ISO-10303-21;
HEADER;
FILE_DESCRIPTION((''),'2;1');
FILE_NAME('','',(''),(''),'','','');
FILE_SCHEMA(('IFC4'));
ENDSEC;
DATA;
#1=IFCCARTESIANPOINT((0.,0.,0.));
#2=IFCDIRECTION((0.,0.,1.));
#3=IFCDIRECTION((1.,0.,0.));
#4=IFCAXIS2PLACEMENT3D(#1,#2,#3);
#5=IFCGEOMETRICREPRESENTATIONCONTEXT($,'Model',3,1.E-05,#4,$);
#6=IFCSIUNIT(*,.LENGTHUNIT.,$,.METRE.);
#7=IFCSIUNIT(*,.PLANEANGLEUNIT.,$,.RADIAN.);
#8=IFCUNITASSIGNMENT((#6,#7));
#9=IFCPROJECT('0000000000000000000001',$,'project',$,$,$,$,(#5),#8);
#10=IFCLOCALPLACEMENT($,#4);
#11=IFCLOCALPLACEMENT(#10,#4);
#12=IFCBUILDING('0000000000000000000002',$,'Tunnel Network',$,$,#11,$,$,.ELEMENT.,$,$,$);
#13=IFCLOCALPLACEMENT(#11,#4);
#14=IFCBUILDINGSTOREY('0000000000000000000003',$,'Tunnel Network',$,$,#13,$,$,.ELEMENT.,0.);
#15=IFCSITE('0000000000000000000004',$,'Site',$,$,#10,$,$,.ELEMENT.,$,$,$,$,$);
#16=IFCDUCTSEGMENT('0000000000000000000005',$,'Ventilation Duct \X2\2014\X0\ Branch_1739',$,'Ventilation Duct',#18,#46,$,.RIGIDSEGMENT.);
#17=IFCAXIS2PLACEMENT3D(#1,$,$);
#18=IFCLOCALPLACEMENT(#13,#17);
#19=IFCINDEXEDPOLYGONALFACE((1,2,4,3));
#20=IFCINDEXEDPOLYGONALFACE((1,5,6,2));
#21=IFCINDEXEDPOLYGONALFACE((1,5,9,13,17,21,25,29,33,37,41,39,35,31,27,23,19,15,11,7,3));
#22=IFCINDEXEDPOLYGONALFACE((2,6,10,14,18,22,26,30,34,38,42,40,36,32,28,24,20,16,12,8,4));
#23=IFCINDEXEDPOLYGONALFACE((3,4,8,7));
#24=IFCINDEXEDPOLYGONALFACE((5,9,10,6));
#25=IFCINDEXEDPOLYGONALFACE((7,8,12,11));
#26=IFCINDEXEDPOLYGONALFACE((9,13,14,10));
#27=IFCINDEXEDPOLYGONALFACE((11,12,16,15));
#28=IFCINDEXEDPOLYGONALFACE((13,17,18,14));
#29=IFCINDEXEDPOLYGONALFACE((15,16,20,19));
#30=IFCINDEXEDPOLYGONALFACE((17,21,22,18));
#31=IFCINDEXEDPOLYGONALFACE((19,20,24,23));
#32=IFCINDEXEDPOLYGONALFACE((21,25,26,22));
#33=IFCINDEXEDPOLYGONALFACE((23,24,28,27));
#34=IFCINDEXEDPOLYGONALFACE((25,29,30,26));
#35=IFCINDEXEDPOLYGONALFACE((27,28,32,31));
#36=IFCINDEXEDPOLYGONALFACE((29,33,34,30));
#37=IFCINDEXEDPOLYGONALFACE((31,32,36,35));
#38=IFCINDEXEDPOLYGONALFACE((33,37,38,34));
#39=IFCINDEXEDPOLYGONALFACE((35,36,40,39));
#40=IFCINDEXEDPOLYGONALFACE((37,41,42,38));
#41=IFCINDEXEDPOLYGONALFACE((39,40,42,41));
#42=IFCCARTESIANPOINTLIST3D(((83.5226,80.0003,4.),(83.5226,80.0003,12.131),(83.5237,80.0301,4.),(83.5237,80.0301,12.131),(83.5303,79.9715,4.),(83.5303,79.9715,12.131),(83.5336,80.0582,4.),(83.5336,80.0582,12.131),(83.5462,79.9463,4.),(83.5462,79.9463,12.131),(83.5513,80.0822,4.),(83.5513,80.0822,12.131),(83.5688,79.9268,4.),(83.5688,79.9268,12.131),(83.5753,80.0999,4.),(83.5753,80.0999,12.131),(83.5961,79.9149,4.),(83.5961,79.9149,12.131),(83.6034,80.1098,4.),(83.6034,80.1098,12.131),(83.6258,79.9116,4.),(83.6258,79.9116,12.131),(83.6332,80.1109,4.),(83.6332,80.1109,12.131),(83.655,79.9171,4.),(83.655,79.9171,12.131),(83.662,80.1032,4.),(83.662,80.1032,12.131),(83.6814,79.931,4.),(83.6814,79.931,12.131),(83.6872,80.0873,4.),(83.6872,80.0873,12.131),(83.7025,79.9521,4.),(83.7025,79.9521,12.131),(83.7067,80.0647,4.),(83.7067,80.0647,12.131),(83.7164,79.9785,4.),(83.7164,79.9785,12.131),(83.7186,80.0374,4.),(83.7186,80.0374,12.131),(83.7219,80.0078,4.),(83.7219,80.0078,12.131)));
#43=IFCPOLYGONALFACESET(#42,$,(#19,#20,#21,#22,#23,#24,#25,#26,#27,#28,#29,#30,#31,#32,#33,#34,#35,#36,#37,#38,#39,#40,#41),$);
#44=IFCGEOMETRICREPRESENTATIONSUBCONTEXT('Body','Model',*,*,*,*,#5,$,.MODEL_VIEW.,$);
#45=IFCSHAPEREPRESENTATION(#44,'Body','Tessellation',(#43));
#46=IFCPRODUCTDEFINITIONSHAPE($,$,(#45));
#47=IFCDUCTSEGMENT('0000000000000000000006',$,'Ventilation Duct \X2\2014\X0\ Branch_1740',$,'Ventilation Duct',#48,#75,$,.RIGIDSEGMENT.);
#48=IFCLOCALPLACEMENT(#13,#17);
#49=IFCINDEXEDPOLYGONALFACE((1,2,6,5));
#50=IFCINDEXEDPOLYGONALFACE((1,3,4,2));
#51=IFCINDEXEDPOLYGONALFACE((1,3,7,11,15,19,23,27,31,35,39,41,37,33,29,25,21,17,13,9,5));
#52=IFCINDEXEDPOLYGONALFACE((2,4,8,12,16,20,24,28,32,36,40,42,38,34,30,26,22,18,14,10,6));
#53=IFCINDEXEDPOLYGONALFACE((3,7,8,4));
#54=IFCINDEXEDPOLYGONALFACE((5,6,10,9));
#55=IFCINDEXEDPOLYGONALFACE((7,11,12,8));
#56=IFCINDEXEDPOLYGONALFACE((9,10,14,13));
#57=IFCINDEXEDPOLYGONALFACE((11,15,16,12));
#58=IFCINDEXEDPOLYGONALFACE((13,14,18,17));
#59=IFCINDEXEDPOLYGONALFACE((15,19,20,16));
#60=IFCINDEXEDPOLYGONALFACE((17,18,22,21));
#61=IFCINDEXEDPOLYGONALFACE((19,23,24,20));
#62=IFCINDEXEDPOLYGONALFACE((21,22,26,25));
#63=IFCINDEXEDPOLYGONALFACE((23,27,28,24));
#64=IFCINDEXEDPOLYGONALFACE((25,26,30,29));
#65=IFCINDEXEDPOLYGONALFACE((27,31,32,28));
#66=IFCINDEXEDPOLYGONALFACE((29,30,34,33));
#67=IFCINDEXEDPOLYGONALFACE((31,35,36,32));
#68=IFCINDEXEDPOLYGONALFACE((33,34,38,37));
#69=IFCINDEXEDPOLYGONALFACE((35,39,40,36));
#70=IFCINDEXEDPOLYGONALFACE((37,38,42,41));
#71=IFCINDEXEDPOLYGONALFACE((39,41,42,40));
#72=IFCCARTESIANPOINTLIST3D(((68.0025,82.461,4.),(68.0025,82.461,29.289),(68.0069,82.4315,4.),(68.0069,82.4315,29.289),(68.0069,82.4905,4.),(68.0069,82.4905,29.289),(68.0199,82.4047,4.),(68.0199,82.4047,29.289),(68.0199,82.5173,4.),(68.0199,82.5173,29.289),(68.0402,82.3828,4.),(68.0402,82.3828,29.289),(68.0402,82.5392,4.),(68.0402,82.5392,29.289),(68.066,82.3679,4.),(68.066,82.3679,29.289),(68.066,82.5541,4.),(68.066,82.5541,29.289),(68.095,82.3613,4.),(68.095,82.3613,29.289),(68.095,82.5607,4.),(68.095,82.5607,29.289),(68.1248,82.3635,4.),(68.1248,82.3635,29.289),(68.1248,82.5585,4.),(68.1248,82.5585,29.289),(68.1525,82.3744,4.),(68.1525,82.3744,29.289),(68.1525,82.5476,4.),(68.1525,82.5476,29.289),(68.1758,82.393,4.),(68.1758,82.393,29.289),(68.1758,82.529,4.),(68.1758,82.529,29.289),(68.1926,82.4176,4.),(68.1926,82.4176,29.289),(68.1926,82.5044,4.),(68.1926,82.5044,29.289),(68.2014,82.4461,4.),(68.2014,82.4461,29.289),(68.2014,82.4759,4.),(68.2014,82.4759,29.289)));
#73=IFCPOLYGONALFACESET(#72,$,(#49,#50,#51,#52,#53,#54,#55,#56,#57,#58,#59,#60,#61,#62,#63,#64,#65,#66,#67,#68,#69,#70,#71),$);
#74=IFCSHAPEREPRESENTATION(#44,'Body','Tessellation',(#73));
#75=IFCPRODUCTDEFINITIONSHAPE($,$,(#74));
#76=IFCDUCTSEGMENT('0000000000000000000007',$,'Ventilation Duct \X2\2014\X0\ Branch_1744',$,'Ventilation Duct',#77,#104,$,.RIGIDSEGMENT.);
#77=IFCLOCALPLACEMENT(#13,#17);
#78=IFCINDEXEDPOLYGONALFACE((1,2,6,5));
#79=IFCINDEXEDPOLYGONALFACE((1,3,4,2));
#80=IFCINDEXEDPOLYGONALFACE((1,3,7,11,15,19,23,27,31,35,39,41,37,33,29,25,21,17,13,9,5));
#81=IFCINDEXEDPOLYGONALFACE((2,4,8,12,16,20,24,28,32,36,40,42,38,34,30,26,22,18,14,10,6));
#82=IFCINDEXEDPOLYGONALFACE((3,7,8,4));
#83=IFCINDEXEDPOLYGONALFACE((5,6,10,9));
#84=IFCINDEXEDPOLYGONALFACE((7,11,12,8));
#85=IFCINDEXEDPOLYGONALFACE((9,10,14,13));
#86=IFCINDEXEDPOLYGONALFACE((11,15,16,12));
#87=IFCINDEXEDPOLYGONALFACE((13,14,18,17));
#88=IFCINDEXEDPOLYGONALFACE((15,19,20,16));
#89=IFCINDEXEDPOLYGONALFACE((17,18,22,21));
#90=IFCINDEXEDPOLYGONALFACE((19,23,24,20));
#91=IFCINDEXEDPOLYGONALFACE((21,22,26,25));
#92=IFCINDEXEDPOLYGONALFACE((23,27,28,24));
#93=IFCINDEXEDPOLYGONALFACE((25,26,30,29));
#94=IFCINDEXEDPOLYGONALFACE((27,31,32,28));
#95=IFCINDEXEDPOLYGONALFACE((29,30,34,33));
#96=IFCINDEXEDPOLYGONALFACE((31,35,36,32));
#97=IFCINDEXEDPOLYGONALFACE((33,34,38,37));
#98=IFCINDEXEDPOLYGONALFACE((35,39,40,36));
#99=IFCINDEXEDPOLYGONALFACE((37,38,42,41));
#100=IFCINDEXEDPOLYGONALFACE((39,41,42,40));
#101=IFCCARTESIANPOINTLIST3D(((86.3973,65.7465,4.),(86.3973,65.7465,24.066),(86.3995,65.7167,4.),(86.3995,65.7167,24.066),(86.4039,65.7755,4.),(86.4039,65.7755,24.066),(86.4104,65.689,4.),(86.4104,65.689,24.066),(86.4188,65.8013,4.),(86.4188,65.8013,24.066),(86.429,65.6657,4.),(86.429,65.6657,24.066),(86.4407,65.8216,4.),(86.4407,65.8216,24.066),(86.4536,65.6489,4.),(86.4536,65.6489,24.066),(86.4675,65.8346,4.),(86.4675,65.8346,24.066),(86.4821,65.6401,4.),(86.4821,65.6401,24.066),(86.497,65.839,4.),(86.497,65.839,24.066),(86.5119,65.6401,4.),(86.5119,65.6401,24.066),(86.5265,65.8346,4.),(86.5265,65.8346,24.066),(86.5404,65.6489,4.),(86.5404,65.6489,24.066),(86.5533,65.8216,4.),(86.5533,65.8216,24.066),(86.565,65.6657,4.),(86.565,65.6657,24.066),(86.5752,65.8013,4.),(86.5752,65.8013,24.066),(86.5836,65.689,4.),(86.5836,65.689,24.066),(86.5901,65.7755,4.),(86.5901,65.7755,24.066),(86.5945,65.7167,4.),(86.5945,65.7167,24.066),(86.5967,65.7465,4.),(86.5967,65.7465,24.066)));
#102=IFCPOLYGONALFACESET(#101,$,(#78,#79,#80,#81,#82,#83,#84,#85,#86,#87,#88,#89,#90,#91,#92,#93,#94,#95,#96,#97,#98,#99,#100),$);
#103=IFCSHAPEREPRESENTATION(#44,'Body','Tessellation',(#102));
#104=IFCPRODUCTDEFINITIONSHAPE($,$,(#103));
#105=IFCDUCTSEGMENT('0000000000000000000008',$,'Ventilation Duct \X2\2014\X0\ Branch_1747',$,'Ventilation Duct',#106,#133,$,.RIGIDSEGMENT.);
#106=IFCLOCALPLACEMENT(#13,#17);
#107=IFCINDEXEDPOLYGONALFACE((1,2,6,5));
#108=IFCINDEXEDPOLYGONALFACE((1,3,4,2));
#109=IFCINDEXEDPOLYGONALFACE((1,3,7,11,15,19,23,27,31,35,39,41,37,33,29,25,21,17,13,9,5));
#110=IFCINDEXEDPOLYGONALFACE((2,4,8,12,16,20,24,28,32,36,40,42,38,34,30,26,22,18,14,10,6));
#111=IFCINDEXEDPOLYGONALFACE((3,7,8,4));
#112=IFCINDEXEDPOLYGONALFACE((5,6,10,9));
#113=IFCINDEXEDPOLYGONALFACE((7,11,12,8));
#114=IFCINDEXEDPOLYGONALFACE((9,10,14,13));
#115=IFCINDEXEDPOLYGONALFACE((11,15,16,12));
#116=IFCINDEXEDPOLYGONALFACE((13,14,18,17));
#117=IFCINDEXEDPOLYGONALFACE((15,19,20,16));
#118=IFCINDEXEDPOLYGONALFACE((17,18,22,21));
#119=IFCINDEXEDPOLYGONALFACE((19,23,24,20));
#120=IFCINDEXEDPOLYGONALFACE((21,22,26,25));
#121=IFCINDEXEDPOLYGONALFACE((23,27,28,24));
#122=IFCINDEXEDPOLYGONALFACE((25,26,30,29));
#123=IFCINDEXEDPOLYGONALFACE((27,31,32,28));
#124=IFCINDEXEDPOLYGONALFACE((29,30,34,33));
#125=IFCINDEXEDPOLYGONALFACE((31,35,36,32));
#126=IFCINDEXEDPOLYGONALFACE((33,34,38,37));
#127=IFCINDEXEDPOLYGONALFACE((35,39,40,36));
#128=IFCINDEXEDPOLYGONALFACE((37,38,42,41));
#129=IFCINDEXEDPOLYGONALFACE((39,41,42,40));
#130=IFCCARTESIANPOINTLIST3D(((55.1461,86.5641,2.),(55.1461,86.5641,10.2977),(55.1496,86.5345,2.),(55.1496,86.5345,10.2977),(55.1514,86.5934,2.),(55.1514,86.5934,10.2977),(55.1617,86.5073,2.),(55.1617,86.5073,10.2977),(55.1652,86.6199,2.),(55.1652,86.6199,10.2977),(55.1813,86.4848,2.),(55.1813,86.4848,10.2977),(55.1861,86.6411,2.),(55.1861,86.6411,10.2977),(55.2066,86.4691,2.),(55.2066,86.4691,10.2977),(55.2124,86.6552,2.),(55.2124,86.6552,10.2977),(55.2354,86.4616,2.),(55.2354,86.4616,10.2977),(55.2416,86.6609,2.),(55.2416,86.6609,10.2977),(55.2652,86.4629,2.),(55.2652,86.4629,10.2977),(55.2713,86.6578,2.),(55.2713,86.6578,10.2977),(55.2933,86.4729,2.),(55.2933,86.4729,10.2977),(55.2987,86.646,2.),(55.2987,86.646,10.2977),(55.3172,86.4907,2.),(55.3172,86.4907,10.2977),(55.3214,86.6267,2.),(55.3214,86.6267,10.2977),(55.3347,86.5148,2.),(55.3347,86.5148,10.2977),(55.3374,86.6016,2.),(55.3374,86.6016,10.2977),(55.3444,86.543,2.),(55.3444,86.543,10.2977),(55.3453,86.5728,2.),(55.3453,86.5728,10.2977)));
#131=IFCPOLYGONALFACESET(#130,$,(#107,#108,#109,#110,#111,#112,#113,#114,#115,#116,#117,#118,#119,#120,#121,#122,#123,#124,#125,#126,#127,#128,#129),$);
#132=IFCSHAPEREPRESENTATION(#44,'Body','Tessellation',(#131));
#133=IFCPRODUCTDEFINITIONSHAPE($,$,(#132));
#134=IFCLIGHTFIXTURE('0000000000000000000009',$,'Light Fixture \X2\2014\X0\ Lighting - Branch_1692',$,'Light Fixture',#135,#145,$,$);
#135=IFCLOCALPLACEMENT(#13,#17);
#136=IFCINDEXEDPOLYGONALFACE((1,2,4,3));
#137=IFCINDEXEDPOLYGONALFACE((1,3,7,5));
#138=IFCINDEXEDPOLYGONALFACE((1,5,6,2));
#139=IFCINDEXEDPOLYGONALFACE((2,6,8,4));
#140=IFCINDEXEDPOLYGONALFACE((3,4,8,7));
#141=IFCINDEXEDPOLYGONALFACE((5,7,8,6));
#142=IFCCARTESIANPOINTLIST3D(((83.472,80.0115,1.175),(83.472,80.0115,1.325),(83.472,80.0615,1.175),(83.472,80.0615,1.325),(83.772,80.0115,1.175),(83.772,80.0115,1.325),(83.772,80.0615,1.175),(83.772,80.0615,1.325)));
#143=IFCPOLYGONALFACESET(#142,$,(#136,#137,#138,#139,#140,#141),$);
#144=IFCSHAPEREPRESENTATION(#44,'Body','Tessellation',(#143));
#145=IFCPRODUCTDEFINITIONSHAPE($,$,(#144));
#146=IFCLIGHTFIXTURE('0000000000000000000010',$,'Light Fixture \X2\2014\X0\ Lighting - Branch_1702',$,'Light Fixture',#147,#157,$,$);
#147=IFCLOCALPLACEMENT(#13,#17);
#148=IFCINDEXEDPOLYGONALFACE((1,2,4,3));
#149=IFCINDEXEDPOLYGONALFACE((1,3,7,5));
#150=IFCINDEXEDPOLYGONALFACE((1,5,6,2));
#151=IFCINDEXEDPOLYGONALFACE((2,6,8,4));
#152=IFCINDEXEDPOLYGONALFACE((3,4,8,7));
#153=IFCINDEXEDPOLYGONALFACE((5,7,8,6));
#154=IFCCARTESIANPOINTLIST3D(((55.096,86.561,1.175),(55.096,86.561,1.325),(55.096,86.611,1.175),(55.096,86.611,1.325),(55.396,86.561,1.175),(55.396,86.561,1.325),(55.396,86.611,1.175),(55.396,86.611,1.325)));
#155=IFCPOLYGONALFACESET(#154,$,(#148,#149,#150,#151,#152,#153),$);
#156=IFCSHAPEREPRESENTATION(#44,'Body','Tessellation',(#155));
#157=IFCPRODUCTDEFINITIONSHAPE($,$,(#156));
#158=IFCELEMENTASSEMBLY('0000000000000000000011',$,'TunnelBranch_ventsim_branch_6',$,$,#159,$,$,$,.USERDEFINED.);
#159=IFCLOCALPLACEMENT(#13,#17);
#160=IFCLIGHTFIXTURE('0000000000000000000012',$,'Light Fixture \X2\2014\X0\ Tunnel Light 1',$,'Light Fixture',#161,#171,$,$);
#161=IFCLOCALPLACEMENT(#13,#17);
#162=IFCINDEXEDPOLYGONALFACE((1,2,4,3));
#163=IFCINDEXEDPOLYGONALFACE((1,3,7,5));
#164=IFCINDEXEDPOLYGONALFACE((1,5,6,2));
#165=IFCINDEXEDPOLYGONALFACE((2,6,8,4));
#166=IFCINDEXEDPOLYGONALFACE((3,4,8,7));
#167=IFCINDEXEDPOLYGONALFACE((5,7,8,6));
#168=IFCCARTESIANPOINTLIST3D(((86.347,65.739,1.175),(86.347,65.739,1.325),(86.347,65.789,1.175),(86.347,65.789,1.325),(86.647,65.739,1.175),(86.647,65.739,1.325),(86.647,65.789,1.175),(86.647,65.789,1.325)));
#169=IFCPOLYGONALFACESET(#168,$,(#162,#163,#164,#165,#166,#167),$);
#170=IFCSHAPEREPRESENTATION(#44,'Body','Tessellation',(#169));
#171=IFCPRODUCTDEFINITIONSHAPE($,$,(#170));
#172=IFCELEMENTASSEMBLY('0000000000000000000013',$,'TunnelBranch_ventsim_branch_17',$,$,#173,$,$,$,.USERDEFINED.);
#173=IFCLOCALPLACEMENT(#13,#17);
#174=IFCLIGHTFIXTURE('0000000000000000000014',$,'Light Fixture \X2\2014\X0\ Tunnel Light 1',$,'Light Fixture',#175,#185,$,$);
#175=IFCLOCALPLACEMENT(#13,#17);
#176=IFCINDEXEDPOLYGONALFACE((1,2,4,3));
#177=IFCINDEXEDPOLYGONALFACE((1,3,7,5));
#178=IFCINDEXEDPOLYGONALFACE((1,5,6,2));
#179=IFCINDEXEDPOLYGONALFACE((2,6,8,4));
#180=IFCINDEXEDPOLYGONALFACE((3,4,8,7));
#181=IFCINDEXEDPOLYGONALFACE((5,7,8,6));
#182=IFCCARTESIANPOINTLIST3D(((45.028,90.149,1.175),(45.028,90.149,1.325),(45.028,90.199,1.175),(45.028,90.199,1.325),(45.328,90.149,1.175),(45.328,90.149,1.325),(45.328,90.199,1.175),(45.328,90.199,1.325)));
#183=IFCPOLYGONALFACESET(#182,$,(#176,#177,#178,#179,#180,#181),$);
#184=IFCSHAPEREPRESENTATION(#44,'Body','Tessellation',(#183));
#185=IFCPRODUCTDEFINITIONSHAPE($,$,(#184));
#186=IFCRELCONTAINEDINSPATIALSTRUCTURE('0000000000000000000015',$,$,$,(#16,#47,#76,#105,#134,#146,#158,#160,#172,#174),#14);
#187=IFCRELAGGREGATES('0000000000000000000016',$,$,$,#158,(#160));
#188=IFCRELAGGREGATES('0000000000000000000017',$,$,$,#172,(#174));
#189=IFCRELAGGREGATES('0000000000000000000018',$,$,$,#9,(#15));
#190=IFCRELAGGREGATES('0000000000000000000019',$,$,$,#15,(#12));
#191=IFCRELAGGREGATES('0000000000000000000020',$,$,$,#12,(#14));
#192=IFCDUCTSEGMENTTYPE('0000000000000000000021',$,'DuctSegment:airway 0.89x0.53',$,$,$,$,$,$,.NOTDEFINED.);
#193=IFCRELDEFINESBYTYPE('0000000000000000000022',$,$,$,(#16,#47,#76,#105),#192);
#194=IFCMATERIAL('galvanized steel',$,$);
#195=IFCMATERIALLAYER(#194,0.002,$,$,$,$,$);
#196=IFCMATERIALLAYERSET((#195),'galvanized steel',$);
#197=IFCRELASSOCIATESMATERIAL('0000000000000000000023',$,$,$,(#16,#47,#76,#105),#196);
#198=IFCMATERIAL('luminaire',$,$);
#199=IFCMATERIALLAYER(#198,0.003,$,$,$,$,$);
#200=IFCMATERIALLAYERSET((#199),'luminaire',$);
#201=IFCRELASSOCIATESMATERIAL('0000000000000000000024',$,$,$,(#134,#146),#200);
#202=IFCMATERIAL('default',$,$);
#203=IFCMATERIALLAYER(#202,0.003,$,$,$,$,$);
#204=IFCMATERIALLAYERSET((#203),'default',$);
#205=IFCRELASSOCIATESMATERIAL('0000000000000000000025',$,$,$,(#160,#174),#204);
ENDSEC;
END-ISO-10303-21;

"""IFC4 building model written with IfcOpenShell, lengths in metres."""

from ifc_helpers import new_model, entity, si_unit, frame, origin_with_axes, origin_2d_with_axis, place, context, subcontext, project, spatial, rectangle, extrude, material, layer, layer_set, layer_usage, type_object, element, aggregate, save


model = new_model("IFC4")

# Units and contexts
model_context = context("Model", 3, precision=1e-05, world=origin_with_axes())
body_context = subcontext(model_context, "Body", "Model", "MODEL_VIEW")
ifc_project = project(units=[si_unit("LENGTHUNIT", "METRE"), si_unit("PLANEANGLEUNIT", "RADIAN")], contexts=[model_context])

# Site, building, storey
site_placement = place(None, origin_with_axes())
site = spatial("IfcSite", under=ifc_project, at=site_placement, Name="Site", CompositionType="ELEMENT")
building_placement = place(site_placement, origin_with_axes())
building = spatial("IfcBuilding", under=site, at=building_placement, Name="Tunnel Network", CompositionType="ELEMENT")
storey_placement = place(building_placement, origin_with_axes())
storey = spatial("IfcBuildingStorey", under=building, at=storey_placement, Name="Tunnel Network", CompositionType="ELEMENT", Elevation=0.0)

# Duct segments
ifc_material_1 = material(Name="galvanized steel")
ifc_layer_1 = layer(ifc_material_1, 0.002)
ifc_layer_set_1 = layer_set([ifc_layer_1], Name="galvanized steel")
ifc_layer_usage_1 = layer_usage(ifc_layer_set_1, "AXIS2", "POSITIVE", 0.0)
duct_segment_type = type_object("IfcDuctSegmentType", Name="DuctSegment:airway 0.89x0.53")
duct_segment_1_placement = place(storey_placement, frame((83.622, 80.0115, 4.0), z_axis=(0.0, 0.0, 1.0), x_axis=(-0.707168, 0.707045, 0.0)))
element("IfcDuctSegment", 1, at=duct_segment_1_placement, inside=storey, type_object=duct_segment_type, material=ifc_layer_usage_1, Name="Ventilation Duct — Branch_1739", ObjectType="Ventilation Duct", PredefinedType="RIGIDSEGMENT", context=body_context, shape_type="AdvancedSweptSolid", body=[
    entity("IfcSweptDiskSolid", entity("IfcPolyline", [entity("IfcCartesianPoint", [0.0, 0.0, 0.0]), entity("IfcCartesianPoint", [0.0, 0.0, 8.131])]), 0.1),
])
ifc_layer_usage_2 = layer_usage(ifc_layer_set_1, "AXIS2", "POSITIVE", 0.0)
duct_segment_2_placement = place(storey_placement, frame((68.1025, 82.461, 4.0), z_axis=(0.0, 0.0, 1.0), x_axis=(-1.0, 0.0, 0.0)))
element("IfcDuctSegment", 2, at=duct_segment_2_placement, inside=storey, type_object=duct_segment_type, material=ifc_layer_usage_2, Name="Ventilation Duct — Branch_1740", ObjectType="Ventilation Duct", PredefinedType="RIGIDSEGMENT", context=body_context, shape_type="AdvancedSweptSolid", body=[
    entity("IfcSweptDiskSolid", entity("IfcPolyline", [entity("IfcCartesianPoint", [0.0, 0.0, 0.0]), entity("IfcCartesianPoint", [0.0, 0.0, 25.289])]), 0.1),
])
ifc_layer_usage_3 = layer_usage(ifc_layer_set_1, "AXIS2", "POSITIVE", 0.0)
duct_segment_3_placement = place(storey_placement, frame((86.497, 65.739, 4.0), z_axis=(0.0, 0.0, 1.0), x_axis=(0.0, 1.0, 0.0)))
element("IfcDuctSegment", 3, at=duct_segment_3_placement, inside=storey, type_object=duct_segment_type, material=ifc_layer_usage_3, Name="Ventilation Duct — Branch_1744", ObjectType="Ventilation Duct", PredefinedType="RIGIDSEGMENT", context=body_context, shape_type="AdvancedSweptSolid", body=[
    entity("IfcSweptDiskSolid", entity("IfcPolyline", [entity("IfcCartesianPoint", [0.0, 0.0, 0.0]), entity("IfcCartesianPoint", [0.0, 0.0, 20.066])]), 0.1),
])
ifc_layer_usage_4 = layer_usage(ifc_layer_set_1, "AXIS2", "POSITIVE", 0.0)
duct_segment_4_placement = place(storey_placement, frame((55.246, 86.561, 2.0), z_axis=(0.0, 0.0, 1.0), x_axis=(-0.043741, 0.999043, 0.0)))
element("IfcDuctSegment", 4, at=duct_segment_4_placement, inside=storey, type_object=duct_segment_type, material=ifc_layer_usage_4, Name="Ventilation Duct — Branch_1747", ObjectType="Ventilation Duct", PredefinedType="RIGIDSEGMENT", context=body_context, shape_type="AdvancedSweptSolid", body=[
    entity("IfcSweptDiskSolid", entity("IfcPolyline", [entity("IfcCartesianPoint", [0.0, 0.0, 0.0]), entity("IfcCartesianPoint", [0.0, 0.0, 8.2977])]), 0.1),
])

# Light fixtures
ifc_material_2 = material(Name="luminaire")
ifc_layer_2 = layer(ifc_material_2, 0.003)
ifc_layer_set_2 = layer_set([ifc_layer_2], Name="luminaire")
ifc_layer_usage_5 = layer_usage(ifc_layer_set_2, "AXIS2", "POSITIVE", 0.0)
light_fixture_1_placement = place(storey_placement, frame((83.622, 80.0115, 1.25), z_axis=(0.0, 1.0, 0.0), x_axis=(-1.0, 0.0, 0.0)))
element("IfcLightFixture", 5, at=light_fixture_1_placement, inside=storey, material=ifc_layer_usage_5, Name="Light Fixture — Lighting - Branch_1692", ObjectType="Light Fixture", context=body_context, shape_type="SweptSolid", body=[
    extrude(rectangle(XDim=0.3, YDim=0.15, at=origin_2d_with_axis()), origin_with_axes(), (0.0, 0.0, 1.0), 0.05),
])
ifc_layer_usage_6 = layer_usage(ifc_layer_set_2, "AXIS2", "POSITIVE", 0.0)
light_fixture_2_placement = place(storey_placement, frame((55.246, 86.561, 1.25), z_axis=(0.0, 1.0, 0.0), x_axis=(-1.0, 0.0, 0.0)))
element("IfcLightFixture", 6, at=light_fixture_2_placement, inside=storey, material=ifc_layer_usage_6, Name="Light Fixture — Lighting - Branch_1702", ObjectType="Light Fixture", context=body_context, shape_type="SweptSolid", body=[
    extrude(rectangle(XDim=0.3, YDim=0.15, at=origin_2d_with_axis()), origin_with_axes(), (0.0, 0.0, 1.0), 0.05),
])

# Element assembly, light fixture
assembly_1_placement = place(storey_placement, frame((86.497, 65.739, 1.25), z_axis=(0.0, 1.0, 0.0), x_axis=(-1.0, 0.0, 0.0)))
assembly_1 = element("IfcElementAssembly", 7, at=assembly_1_placement, inside=storey, Name="TunnelBranch_ventsim_branch_6", PredefinedType="USERDEFINED")
ifc_material_3 = material(Name="default")
ifc_layer_3 = layer(ifc_material_3, 0.003)
ifc_layer_set_3 = layer_set([ifc_layer_3], Name="default")
ifc_layer_usage_7 = layer_usage(ifc_layer_set_3, "AXIS2", "POSITIVE", 0.0)
light_fixture_3_placement = place(storey_placement, frame((86.497, 65.739, 1.25), z_axis=(0.0, 1.0, 0.0), x_axis=(-1.0, 0.0, 0.0)))
light_fixture_3 = element("IfcLightFixture", 8, at=light_fixture_3_placement, inside=storey, material=ifc_layer_usage_7, Name="Light Fixture — Tunnel Light 1", ObjectType="Light Fixture", context=body_context, shape_type="SweptSolid", body=[
    extrude(rectangle(XDim=0.3, YDim=0.15, at=origin_2d_with_axis()), origin_with_axes(), (0.0, 0.0, 1.0), 0.05),
])
aggregate(assembly_1, [light_fixture_3])

# Element assembly, light fixture
assembly_2_placement = place(storey_placement, frame((45.178, 90.149, 1.25), z_axis=(0.0, 1.0, 0.0), x_axis=(-1.0, 0.0, 0.0)))
assembly_2 = element("IfcElementAssembly", 9, at=assembly_2_placement, inside=storey, Name="TunnelBranch_ventsim_branch_17", PredefinedType="USERDEFINED")
ifc_layer_usage_8 = layer_usage(ifc_layer_set_3, "AXIS2", "POSITIVE", 0.0)
light_fixture_4_placement = place(storey_placement, frame((45.178, 90.149, 1.25), z_axis=(0.0, 1.0, 0.0), x_axis=(-1.0, 0.0, 0.0)))
light_fixture_4 = element("IfcLightFixture", 10, at=light_fixture_4_placement, inside=storey, material=ifc_layer_usage_8, Name="Light Fixture — Tunnel Light 1", ObjectType="Light Fixture", context=body_context, shape_type="SweptSolid", body=[
    extrude(rectangle(XDim=0.3, YDim=0.15, at=origin_2d_with_axis()), origin_with_axes(), (0.0, 0.0, 1.0), 0.05),
])
aggregate(assembly_2, [light_fixture_4])

save(model, "model.ifc")
